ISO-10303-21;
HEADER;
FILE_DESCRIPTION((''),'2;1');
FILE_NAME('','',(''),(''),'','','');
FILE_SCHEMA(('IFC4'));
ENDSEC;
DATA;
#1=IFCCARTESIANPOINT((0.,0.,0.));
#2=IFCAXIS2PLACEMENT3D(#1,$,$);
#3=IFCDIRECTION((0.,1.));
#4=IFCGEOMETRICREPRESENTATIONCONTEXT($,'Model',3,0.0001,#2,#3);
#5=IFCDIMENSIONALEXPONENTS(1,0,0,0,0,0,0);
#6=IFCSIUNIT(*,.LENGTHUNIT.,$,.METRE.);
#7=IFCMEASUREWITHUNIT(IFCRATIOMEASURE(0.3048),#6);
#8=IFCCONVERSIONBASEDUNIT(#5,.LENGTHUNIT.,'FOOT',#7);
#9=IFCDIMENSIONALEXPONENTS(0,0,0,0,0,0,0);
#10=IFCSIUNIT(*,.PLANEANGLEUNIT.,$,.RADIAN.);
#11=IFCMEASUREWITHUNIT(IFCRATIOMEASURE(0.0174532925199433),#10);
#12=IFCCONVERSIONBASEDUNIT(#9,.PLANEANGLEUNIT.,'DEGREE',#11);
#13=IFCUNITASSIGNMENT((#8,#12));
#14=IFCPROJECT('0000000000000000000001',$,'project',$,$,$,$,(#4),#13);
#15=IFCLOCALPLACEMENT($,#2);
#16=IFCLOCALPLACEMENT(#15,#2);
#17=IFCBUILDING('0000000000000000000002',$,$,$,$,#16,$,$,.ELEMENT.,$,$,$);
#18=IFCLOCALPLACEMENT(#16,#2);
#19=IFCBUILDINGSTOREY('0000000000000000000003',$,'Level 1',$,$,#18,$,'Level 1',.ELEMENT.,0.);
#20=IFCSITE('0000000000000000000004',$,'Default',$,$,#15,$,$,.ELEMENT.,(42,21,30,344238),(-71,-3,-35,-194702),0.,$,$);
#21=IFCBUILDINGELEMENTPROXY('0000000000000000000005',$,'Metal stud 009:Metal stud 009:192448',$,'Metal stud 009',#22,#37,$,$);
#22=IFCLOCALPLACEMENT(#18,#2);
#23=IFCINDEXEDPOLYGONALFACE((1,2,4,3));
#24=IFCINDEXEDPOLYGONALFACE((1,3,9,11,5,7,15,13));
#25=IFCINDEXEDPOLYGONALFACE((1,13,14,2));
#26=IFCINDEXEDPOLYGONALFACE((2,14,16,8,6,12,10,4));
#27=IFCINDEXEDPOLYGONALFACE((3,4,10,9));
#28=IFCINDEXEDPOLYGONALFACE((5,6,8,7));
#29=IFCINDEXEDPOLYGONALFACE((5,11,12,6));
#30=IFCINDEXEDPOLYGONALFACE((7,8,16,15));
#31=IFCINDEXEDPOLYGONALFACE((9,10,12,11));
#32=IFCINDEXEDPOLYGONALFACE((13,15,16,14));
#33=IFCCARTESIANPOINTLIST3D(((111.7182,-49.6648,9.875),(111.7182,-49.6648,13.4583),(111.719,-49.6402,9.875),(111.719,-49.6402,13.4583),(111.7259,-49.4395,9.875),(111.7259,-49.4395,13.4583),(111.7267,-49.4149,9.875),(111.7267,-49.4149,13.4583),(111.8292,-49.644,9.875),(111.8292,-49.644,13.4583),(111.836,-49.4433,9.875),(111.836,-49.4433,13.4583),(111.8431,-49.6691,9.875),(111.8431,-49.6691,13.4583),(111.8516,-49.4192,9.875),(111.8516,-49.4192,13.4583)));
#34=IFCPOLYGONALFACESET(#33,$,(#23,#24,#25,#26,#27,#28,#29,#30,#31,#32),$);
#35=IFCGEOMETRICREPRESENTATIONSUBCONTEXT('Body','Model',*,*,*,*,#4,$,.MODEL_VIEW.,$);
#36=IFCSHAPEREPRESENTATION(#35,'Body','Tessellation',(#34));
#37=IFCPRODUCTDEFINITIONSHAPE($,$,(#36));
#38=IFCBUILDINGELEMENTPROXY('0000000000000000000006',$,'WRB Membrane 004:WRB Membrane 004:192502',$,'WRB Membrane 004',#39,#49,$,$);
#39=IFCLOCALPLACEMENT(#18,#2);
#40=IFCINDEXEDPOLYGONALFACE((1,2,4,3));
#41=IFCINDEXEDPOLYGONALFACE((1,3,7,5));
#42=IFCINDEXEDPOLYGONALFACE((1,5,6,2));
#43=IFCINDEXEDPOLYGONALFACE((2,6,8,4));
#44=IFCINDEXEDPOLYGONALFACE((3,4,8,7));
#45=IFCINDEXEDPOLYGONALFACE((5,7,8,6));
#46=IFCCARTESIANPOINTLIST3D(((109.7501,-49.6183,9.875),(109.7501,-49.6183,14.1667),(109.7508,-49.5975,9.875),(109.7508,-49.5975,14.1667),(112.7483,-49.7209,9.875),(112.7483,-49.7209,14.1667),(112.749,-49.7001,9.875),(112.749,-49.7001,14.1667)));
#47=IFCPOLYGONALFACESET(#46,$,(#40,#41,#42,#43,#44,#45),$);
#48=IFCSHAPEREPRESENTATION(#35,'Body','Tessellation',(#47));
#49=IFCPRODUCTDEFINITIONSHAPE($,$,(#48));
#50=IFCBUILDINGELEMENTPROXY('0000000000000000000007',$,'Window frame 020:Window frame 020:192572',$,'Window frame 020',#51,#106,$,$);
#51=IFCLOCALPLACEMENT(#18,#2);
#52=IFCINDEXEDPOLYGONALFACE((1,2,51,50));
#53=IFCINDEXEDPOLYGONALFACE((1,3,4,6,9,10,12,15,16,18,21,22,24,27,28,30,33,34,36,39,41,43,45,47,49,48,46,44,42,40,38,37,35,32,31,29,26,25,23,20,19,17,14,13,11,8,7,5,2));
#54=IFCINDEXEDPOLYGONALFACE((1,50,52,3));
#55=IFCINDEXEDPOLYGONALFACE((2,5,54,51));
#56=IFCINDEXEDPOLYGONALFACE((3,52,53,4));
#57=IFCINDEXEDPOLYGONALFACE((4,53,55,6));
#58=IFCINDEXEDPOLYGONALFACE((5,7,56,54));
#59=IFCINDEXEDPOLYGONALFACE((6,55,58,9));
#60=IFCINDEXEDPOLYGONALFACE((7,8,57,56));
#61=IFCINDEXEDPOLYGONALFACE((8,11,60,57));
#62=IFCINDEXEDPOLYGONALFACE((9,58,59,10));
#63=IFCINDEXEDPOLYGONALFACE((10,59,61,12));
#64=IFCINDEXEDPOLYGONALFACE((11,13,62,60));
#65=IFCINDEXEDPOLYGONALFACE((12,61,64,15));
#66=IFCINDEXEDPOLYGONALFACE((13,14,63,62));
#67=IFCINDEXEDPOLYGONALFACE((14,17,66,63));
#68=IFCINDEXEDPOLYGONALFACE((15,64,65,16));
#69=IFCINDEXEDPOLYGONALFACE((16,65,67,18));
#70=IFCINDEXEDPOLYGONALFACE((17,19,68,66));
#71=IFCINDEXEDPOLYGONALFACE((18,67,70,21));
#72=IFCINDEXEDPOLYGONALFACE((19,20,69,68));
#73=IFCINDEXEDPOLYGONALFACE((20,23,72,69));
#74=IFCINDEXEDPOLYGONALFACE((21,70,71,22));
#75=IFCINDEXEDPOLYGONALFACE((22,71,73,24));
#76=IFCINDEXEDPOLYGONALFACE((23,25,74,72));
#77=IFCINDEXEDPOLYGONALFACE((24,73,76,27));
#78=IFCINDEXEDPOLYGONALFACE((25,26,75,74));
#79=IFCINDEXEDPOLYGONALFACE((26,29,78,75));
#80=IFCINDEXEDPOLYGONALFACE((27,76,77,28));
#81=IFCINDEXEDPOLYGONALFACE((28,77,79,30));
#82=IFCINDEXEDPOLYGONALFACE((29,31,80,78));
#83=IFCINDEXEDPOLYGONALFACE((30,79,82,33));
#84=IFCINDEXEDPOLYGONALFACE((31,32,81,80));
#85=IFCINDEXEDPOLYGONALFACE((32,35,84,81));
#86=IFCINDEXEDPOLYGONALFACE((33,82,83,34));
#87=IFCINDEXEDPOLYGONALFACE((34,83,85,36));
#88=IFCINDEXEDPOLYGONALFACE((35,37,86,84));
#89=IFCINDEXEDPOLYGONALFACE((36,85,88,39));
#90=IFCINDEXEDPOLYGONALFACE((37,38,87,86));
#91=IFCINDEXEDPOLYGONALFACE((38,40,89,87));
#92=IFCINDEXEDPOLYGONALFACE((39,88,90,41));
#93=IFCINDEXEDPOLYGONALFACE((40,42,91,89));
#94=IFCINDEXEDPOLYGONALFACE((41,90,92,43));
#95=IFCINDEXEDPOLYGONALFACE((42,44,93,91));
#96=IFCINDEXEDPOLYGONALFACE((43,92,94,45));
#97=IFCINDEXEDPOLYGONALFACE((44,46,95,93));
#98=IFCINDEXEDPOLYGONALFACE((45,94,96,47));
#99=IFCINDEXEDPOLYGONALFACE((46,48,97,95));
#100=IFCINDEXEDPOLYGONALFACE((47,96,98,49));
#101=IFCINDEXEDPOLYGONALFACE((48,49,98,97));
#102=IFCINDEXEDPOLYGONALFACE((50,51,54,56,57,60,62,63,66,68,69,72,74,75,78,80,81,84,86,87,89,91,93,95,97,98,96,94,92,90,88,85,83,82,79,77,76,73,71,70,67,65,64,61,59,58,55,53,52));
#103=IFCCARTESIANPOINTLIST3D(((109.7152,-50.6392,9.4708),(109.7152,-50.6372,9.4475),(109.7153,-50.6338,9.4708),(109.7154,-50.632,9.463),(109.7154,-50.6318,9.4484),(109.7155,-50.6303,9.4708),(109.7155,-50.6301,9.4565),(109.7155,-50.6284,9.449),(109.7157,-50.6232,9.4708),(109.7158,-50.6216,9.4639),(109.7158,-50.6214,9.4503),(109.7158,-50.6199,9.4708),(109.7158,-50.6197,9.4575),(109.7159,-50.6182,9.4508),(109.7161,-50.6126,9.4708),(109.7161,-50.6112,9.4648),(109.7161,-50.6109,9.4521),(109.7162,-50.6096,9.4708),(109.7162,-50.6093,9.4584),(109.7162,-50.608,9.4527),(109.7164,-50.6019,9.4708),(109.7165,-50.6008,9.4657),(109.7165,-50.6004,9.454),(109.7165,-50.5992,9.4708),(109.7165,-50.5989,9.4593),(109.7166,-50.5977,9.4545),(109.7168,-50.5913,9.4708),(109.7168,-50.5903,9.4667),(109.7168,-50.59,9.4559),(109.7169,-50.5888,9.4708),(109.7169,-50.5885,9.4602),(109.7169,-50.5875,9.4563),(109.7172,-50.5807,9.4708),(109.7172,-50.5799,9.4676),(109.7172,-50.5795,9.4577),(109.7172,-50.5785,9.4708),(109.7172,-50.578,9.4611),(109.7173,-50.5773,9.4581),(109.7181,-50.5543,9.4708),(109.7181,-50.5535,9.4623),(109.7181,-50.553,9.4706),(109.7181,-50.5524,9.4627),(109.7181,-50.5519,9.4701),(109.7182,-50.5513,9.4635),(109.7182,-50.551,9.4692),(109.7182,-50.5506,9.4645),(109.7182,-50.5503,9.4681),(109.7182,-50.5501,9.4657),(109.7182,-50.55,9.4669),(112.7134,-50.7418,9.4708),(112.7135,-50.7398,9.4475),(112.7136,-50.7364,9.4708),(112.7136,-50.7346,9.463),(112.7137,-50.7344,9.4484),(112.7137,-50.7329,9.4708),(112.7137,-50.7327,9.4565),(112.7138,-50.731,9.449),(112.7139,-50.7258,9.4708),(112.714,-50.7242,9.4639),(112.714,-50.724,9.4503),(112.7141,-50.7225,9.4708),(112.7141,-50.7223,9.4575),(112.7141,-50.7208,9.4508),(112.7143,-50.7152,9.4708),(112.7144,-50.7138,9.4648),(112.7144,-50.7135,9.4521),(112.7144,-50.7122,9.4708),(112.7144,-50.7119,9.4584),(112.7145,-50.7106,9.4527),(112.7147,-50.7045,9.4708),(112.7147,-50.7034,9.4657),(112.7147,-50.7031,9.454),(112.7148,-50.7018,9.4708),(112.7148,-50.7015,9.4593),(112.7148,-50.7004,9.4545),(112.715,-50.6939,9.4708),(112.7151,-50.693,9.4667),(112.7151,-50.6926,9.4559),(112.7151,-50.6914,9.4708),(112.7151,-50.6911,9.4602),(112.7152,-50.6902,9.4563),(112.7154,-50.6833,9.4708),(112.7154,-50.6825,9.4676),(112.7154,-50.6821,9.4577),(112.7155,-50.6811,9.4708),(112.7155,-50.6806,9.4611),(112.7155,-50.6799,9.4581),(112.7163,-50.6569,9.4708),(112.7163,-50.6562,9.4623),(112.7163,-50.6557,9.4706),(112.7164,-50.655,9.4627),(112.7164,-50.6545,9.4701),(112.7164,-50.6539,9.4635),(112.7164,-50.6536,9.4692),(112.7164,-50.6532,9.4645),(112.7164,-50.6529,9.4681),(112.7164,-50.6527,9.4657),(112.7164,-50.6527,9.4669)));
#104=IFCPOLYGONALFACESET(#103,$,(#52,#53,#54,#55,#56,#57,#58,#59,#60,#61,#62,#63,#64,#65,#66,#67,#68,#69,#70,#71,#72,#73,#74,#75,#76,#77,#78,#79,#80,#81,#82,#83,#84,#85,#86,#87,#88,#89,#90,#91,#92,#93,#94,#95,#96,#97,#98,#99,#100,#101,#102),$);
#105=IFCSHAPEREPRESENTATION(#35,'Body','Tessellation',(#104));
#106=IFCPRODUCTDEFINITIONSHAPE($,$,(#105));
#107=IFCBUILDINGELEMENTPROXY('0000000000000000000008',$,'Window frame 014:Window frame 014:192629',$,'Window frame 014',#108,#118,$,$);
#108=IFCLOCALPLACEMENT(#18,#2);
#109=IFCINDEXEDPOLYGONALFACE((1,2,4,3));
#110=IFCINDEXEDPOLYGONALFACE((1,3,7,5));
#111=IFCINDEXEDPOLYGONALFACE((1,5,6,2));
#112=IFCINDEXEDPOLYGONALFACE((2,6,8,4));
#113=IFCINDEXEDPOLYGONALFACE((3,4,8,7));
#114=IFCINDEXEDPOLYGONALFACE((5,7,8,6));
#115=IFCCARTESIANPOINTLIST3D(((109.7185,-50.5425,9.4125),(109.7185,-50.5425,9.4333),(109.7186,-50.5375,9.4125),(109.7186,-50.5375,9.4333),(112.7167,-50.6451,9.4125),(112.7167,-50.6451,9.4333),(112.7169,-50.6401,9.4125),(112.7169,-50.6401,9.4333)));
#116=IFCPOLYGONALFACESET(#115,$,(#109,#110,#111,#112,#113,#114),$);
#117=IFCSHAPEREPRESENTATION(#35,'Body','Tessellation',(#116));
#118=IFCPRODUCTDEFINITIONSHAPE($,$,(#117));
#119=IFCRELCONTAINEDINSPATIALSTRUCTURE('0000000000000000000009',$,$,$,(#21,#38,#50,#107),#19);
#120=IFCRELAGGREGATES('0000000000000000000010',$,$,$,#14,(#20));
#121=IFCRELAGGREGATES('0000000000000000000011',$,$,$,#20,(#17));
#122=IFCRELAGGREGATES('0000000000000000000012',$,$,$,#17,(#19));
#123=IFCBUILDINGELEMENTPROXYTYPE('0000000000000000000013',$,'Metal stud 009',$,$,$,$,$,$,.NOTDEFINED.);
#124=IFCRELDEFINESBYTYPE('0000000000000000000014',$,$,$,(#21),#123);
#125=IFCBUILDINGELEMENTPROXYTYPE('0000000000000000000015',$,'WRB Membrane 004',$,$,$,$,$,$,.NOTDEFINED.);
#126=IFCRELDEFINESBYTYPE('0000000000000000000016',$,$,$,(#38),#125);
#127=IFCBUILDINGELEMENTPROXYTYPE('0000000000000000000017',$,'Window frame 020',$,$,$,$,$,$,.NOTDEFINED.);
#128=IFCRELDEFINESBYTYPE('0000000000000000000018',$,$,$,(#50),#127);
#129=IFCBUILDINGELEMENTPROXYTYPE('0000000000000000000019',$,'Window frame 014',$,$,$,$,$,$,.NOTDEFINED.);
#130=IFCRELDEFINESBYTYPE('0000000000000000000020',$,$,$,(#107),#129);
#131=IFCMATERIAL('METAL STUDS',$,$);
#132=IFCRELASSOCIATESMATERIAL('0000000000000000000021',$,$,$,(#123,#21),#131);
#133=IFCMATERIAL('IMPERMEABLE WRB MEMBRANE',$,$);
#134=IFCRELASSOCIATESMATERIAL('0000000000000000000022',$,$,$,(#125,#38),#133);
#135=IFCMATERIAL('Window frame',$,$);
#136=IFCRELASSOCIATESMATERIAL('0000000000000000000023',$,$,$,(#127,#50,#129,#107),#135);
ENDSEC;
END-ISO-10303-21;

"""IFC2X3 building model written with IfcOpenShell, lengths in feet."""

from ifc_helpers import new_model, entity, si_unit, converted_unit, direction, frame, frame_2d, origin, place, context, subcontext, project, spatial, polyline, circle_curve, parameter, trimmed, segment, composite_curve, rectangle, outline, extrude, source, transform, mapped, material, type_object, type_shapes, element, save


model = new_model("IFC2X3")

# Units and contexts
model_context = context("Model", 3, precision=0.0001, world=origin(), true_north=direction((0.0, 1.0)))
body_context = subcontext(model_context, "Body", "Model", "MODEL_VIEW")
ifc_project = project(units=[converted_unit("LENGTHUNIT", "FOOT", entity("IfcRatioMeasure", 0.3048), si_unit("LENGTHUNIT", "METRE"), dimensions=[1, 0, 0, 0, 0, 0, 0]), converted_unit("PLANEANGLEUNIT", "DEGREE", entity("IfcRatioMeasure", 0.0174532925199433), si_unit("PLANEANGLEUNIT", "RADIAN"), dimensions=[0, 0, 0, 0, 0, 0, 0])], contexts=[model_context])

# Site, building, storey
site_placement = place(None, origin())
site = spatial("IfcSite", under=ifc_project, at=site_placement, Name="Default", CompositionType="ELEMENT", RefLatitude=(42, 21, 30, 344238), RefLongitude=(-71, -3, -35, -194702), RefElevation=0.0)
building_placement = place(site_placement, origin())
building = spatial("IfcBuilding", under=site, at=building_placement, CompositionType="ELEMENT")
storey_placement = place(building_placement, origin())
storey = spatial("IfcBuildingStorey", under=building, at=storey_placement, Name="Level 1", LongName="Level 1", CompositionType="ELEMENT", Elevation=0.0)

# Building element proxies
ifc_material_1 = material(Name="METAL STUDS")
building_element_proxy_type_1 = type_object("IfcBuildingElementProxyType", Name="Metal stud 009", PredefinedType="NOTDEFINED", material=ifc_material_1)
shared_shape_1 = source(origin(), body_context, "Body", "SweptSolid", [
    extrude(outline(polyline([(-0.0662, -0.125), (0.0588, -0.125), (0.0588, -0.1004), (-0.0514, -0.1004), (-0.0514, 0.1004), (0.0588, 0.1004), (0.0588, 0.125), (-0.0662, 0.125), (-0.0662, -0.125)])), frame((111.7812, -49.5419, 9.875), z_axis=(0.0, 0.0, 1.0), x_axis=(-0.999415, 0.034202, 0.0)), (0.0, 0.0, 1.0), 3.5833),
])
type_shapes(building_element_proxy_type_1, [shared_shape_1])
proxy_1_placement = place(storey_placement, origin())
element("IfcBuildingElementProxy", 1, at=proxy_1_placement, inside=storey, type_object=building_element_proxy_type_1, material=ifc_material_1, Name="Metal stud 009:Metal stud 009:192448", ObjectType="Metal stud 009", context=body_context, shape_type="MappedRepresentation", body=[
    mapped(shared_shape_1, transform((0.0, 0.0, 0.0), scale=1.0)),
])
ifc_material_2 = material(Name="IMPERMEABLE WRB MEMBRANE")
building_element_proxy_type_2 = type_object("IfcBuildingElementProxyType", Name="WRB Membrane 004", PredefinedType="NOTDEFINED", material=ifc_material_2)
shared_shape_2 = source(origin(), body_context, "Body", "SweptSolid", [
    extrude(rectangle(XDim=3.0, YDim=0.0208, at=frame_2d((0.0, 0.0), x_axis=(1.0, 0.0))), frame((111.2496, -49.6592, 9.875), z_axis=(0.0, 0.0, 1.0), x_axis=(-0.999415, 0.034202, 0.0)), (0.0, 0.0, 1.0), 4.2917),
])
type_shapes(building_element_proxy_type_2, [shared_shape_2])
proxy_2_placement = place(storey_placement, origin())
element("IfcBuildingElementProxy", 2, at=proxy_2_placement, inside=storey, type_object=building_element_proxy_type_2, material=ifc_material_2, Name="WRB Membrane 004:WRB Membrane 004:192502", ObjectType="WRB Membrane 004", context=body_context, shape_type="MappedRepresentation", body=[
    mapped(shared_shape_2, transform((0.0, 0.0, 0.0), scale=1.0)),
])
ifc_material_3 = material(Name="Window frame")
building_element_proxy_type_3 = type_object("IfcBuildingElementProxyType", Name="Window frame 020", PredefinedType="NOTDEFINED", material=ifc_material_3)
shared_shape_3 = source(origin(), body_context, "Body", "SweptSolid", [
    extrude(outline(composite_curve([segment(polyline([(-0.0351, -0.0087), (-0.0297, -0.0087)]), True, "CONTINUOUS"), segment(polyline([(-0.0297, -0.0087), (-0.0266, -0.001)]), True, "CONTINUOUS"), segment(polyline([(-0.0266, -0.001), (-0.0262, -0.0087)]), True, "CONTINUOUS"), segment(polyline([(-0.0262, -0.0087), (-0.0191, -0.0087)]), True, "CONTINUOUS"), segment(polyline([(-0.0191, -0.0087), (-0.0161, -0.0019)]), True, "CONTINUOUS"), segment(polyline([(-0.0161, -0.0019), (-0.0158, -0.0087)]), True, "CONTINUOUS"), segment(polyline([(-0.0158, -0.0087), (-0.0084, -0.0087)]), True, "CONTINUOUS"), segment(polyline([(-0.0084, -0.0087), (-0.0057, -0.0028)]), True, "CONTINUOUS"), segment(polyline([(-0.0057, -0.0028), (-0.0054, -0.0087)]), True, "CONTINUOUS"), segment(polyline([(-0.0054, -0.0087), (0.0022, -0.0087)]), True, "CONTINUOUS"), segment(polyline([(0.0022, -0.0087), (0.0047, -0.0037)]), True, "CONTINUOUS"), segment(polyline([(0.0047, -0.0037), (0.0049, -0.0087)]), True, "CONTINUOUS"), segment(polyline([(0.0049, -0.0087), (0.0128, -0.0087)]), True, "CONTINUOUS"), segment(polyline([(0.0128, -0.0087), (0.0151, -0.0046)]), True, "CONTINUOUS"), segment(polyline([(0.0151, -0.0046), (0.0153, -0.0087)]), True, "CONTINUOUS"), segment(polyline([(0.0153, -0.0087), (0.0235, -0.0087)]), True, "CONTINUOUS"), segment(polyline([(0.0235, -0.0087), (0.0255, -0.0056)]), True, "CONTINUOUS"), segment(polyline([(0.0255, -0.0056), (0.0257, -0.0087)]), True, "CONTINUOUS"), segment(polyline([(0.0257, -0.0087), (0.0499, -0.0087)]), True, "CONTINUOUS"), segment(trimmed(circle_curve(frame_2d((0.0499, -0.0044), x_axis=(-0.984549, 0.175111)), 0.0043), [parameter(100.085127)], [parameter(269.994873)], True, "PARAMETER"), True, "CONTINUOUS"), segment(polyline([(0.0506, -0.0002), (0.0268, 0.004)]), True, "CONTINUOUS"), segment(polyline([(0.0268, 0.004), (0.0248, 0.0011)]), True, "CONTINUOUS"), segment(polyline([(0.0248, 0.0011), (0.0246, 0.0044)]), True, "CONTINUOUS"), segment(polyline([(0.0246, 0.0044), (0.0166, 0.0058)]), True, "CONTINUOUS"), segment(polyline([(0.0166, 0.0058), (0.0144, 0.002)]), True, "CONTINUOUS"), segment(polyline([(0.0144, 0.002), (0.0142, 0.0063)]), True, "CONTINUOUS"), segment(polyline([(0.0142, 0.0063), (0.0064, 0.0077)]), True, "CONTINUOUS"), segment(polyline([(0.0064, 0.0077), (0.004, 0.003)]), True, "CONTINUOUS"), segment(polyline([(0.004, 0.003), (0.0037, 0.0081)]), True, "CONTINUOUS"), segment(polyline([(0.0037, 0.0081), (-0.0038, 0.0095)]), True, "CONTINUOUS"), segment(polyline([(-0.0038, 0.0095), (-0.0065, 0.0039)]), True, "CONTINUOUS"), segment(polyline([(-0.0065, 0.0039), (-0.0068, 0.01)]), True, "CONTINUOUS"), segment(polyline([(-0.0068, 0.01), (-0.014, 0.0113)]), True, "CONTINUOUS"), segment(polyline([(-0.014, 0.0113), (-0.0169, 0.0048)]), True, "CONTINUOUS"), segment(polyline([(-0.0169, 0.0048), (-0.0172, 0.0119)]), True, "CONTINUOUS"), segment(polyline([(-0.0172, 0.0119), (-0.0242, 0.0131)]), True, "CONTINUOUS"), segment(polyline([(-0.0242, 0.0131), (-0.0273, 0.0057)]), True, "CONTINUOUS"), segment(polyline([(-0.0273, 0.0057), (-0.0277, 0.0137)]), True, "CONTINUOUS"), segment(polyline([(-0.0277, 0.0137), (-0.0331, 0.0147)]), True, "CONTINUOUS"), segment(polyline([(-0.0331, 0.0147), (-0.0351, -0.0087)]), True, "CONTINUOUS")], self_intersect=False)), frame((109.7164, -50.6041, 9.4621), z_axis=(0.999415, -0.034202, 0.0), x_axis=(0.033673, 0.983973, 0.175111)), (0.0, 0.0, 1.0), 3.0),
])
type_shapes(building_element_proxy_type_3, [shared_shape_3])
proxy_3_placement = place(storey_placement, origin())
element("IfcBuildingElementProxy", 3, at=proxy_3_placement, inside=storey, type_object=building_element_proxy_type_3, material=ifc_material_3, Name="Window frame 020:Window frame 020:192572", ObjectType="Window frame 020", context=body_context, shape_type="MappedRepresentation", body=[
    mapped(shared_shape_3, transform((0.0, 0.0, 0.0), scale=1.0)),
])
building_element_proxy_type_4 = type_object("IfcBuildingElementProxyType", Name="Window frame 014", PredefinedType="NOTDEFINED", material=ifc_material_3)
shared_shape_4 = source(origin(), body_context, "Body", "SweptSolid", [
    extrude(rectangle(XDim=3.0, YDim=0.005, at=frame_2d((0.0, 0.0), x_axis=(1.0, 0.0))), frame((111.2177, -50.5913, 9.4125), z_axis=(0.0, 0.0, 1.0), x_axis=(-0.999415, 0.034202, 0.0)), (0.0, 0.0, 1.0), 0.0208),
])
type_shapes(building_element_proxy_type_4, [shared_shape_4])
proxy_4_placement = place(storey_placement, origin())
element("IfcBuildingElementProxy", 4, at=proxy_4_placement, inside=storey, type_object=building_element_proxy_type_4, material=ifc_material_3, Name="Window frame 014:Window frame 014:192629", ObjectType="Window frame 014", context=body_context, shape_type="MappedRepresentation", body=[
    mapped(shared_shape_4, transform((0.0, 0.0, 0.0), scale=1.0)),
])

save(model, "model.ifc")
